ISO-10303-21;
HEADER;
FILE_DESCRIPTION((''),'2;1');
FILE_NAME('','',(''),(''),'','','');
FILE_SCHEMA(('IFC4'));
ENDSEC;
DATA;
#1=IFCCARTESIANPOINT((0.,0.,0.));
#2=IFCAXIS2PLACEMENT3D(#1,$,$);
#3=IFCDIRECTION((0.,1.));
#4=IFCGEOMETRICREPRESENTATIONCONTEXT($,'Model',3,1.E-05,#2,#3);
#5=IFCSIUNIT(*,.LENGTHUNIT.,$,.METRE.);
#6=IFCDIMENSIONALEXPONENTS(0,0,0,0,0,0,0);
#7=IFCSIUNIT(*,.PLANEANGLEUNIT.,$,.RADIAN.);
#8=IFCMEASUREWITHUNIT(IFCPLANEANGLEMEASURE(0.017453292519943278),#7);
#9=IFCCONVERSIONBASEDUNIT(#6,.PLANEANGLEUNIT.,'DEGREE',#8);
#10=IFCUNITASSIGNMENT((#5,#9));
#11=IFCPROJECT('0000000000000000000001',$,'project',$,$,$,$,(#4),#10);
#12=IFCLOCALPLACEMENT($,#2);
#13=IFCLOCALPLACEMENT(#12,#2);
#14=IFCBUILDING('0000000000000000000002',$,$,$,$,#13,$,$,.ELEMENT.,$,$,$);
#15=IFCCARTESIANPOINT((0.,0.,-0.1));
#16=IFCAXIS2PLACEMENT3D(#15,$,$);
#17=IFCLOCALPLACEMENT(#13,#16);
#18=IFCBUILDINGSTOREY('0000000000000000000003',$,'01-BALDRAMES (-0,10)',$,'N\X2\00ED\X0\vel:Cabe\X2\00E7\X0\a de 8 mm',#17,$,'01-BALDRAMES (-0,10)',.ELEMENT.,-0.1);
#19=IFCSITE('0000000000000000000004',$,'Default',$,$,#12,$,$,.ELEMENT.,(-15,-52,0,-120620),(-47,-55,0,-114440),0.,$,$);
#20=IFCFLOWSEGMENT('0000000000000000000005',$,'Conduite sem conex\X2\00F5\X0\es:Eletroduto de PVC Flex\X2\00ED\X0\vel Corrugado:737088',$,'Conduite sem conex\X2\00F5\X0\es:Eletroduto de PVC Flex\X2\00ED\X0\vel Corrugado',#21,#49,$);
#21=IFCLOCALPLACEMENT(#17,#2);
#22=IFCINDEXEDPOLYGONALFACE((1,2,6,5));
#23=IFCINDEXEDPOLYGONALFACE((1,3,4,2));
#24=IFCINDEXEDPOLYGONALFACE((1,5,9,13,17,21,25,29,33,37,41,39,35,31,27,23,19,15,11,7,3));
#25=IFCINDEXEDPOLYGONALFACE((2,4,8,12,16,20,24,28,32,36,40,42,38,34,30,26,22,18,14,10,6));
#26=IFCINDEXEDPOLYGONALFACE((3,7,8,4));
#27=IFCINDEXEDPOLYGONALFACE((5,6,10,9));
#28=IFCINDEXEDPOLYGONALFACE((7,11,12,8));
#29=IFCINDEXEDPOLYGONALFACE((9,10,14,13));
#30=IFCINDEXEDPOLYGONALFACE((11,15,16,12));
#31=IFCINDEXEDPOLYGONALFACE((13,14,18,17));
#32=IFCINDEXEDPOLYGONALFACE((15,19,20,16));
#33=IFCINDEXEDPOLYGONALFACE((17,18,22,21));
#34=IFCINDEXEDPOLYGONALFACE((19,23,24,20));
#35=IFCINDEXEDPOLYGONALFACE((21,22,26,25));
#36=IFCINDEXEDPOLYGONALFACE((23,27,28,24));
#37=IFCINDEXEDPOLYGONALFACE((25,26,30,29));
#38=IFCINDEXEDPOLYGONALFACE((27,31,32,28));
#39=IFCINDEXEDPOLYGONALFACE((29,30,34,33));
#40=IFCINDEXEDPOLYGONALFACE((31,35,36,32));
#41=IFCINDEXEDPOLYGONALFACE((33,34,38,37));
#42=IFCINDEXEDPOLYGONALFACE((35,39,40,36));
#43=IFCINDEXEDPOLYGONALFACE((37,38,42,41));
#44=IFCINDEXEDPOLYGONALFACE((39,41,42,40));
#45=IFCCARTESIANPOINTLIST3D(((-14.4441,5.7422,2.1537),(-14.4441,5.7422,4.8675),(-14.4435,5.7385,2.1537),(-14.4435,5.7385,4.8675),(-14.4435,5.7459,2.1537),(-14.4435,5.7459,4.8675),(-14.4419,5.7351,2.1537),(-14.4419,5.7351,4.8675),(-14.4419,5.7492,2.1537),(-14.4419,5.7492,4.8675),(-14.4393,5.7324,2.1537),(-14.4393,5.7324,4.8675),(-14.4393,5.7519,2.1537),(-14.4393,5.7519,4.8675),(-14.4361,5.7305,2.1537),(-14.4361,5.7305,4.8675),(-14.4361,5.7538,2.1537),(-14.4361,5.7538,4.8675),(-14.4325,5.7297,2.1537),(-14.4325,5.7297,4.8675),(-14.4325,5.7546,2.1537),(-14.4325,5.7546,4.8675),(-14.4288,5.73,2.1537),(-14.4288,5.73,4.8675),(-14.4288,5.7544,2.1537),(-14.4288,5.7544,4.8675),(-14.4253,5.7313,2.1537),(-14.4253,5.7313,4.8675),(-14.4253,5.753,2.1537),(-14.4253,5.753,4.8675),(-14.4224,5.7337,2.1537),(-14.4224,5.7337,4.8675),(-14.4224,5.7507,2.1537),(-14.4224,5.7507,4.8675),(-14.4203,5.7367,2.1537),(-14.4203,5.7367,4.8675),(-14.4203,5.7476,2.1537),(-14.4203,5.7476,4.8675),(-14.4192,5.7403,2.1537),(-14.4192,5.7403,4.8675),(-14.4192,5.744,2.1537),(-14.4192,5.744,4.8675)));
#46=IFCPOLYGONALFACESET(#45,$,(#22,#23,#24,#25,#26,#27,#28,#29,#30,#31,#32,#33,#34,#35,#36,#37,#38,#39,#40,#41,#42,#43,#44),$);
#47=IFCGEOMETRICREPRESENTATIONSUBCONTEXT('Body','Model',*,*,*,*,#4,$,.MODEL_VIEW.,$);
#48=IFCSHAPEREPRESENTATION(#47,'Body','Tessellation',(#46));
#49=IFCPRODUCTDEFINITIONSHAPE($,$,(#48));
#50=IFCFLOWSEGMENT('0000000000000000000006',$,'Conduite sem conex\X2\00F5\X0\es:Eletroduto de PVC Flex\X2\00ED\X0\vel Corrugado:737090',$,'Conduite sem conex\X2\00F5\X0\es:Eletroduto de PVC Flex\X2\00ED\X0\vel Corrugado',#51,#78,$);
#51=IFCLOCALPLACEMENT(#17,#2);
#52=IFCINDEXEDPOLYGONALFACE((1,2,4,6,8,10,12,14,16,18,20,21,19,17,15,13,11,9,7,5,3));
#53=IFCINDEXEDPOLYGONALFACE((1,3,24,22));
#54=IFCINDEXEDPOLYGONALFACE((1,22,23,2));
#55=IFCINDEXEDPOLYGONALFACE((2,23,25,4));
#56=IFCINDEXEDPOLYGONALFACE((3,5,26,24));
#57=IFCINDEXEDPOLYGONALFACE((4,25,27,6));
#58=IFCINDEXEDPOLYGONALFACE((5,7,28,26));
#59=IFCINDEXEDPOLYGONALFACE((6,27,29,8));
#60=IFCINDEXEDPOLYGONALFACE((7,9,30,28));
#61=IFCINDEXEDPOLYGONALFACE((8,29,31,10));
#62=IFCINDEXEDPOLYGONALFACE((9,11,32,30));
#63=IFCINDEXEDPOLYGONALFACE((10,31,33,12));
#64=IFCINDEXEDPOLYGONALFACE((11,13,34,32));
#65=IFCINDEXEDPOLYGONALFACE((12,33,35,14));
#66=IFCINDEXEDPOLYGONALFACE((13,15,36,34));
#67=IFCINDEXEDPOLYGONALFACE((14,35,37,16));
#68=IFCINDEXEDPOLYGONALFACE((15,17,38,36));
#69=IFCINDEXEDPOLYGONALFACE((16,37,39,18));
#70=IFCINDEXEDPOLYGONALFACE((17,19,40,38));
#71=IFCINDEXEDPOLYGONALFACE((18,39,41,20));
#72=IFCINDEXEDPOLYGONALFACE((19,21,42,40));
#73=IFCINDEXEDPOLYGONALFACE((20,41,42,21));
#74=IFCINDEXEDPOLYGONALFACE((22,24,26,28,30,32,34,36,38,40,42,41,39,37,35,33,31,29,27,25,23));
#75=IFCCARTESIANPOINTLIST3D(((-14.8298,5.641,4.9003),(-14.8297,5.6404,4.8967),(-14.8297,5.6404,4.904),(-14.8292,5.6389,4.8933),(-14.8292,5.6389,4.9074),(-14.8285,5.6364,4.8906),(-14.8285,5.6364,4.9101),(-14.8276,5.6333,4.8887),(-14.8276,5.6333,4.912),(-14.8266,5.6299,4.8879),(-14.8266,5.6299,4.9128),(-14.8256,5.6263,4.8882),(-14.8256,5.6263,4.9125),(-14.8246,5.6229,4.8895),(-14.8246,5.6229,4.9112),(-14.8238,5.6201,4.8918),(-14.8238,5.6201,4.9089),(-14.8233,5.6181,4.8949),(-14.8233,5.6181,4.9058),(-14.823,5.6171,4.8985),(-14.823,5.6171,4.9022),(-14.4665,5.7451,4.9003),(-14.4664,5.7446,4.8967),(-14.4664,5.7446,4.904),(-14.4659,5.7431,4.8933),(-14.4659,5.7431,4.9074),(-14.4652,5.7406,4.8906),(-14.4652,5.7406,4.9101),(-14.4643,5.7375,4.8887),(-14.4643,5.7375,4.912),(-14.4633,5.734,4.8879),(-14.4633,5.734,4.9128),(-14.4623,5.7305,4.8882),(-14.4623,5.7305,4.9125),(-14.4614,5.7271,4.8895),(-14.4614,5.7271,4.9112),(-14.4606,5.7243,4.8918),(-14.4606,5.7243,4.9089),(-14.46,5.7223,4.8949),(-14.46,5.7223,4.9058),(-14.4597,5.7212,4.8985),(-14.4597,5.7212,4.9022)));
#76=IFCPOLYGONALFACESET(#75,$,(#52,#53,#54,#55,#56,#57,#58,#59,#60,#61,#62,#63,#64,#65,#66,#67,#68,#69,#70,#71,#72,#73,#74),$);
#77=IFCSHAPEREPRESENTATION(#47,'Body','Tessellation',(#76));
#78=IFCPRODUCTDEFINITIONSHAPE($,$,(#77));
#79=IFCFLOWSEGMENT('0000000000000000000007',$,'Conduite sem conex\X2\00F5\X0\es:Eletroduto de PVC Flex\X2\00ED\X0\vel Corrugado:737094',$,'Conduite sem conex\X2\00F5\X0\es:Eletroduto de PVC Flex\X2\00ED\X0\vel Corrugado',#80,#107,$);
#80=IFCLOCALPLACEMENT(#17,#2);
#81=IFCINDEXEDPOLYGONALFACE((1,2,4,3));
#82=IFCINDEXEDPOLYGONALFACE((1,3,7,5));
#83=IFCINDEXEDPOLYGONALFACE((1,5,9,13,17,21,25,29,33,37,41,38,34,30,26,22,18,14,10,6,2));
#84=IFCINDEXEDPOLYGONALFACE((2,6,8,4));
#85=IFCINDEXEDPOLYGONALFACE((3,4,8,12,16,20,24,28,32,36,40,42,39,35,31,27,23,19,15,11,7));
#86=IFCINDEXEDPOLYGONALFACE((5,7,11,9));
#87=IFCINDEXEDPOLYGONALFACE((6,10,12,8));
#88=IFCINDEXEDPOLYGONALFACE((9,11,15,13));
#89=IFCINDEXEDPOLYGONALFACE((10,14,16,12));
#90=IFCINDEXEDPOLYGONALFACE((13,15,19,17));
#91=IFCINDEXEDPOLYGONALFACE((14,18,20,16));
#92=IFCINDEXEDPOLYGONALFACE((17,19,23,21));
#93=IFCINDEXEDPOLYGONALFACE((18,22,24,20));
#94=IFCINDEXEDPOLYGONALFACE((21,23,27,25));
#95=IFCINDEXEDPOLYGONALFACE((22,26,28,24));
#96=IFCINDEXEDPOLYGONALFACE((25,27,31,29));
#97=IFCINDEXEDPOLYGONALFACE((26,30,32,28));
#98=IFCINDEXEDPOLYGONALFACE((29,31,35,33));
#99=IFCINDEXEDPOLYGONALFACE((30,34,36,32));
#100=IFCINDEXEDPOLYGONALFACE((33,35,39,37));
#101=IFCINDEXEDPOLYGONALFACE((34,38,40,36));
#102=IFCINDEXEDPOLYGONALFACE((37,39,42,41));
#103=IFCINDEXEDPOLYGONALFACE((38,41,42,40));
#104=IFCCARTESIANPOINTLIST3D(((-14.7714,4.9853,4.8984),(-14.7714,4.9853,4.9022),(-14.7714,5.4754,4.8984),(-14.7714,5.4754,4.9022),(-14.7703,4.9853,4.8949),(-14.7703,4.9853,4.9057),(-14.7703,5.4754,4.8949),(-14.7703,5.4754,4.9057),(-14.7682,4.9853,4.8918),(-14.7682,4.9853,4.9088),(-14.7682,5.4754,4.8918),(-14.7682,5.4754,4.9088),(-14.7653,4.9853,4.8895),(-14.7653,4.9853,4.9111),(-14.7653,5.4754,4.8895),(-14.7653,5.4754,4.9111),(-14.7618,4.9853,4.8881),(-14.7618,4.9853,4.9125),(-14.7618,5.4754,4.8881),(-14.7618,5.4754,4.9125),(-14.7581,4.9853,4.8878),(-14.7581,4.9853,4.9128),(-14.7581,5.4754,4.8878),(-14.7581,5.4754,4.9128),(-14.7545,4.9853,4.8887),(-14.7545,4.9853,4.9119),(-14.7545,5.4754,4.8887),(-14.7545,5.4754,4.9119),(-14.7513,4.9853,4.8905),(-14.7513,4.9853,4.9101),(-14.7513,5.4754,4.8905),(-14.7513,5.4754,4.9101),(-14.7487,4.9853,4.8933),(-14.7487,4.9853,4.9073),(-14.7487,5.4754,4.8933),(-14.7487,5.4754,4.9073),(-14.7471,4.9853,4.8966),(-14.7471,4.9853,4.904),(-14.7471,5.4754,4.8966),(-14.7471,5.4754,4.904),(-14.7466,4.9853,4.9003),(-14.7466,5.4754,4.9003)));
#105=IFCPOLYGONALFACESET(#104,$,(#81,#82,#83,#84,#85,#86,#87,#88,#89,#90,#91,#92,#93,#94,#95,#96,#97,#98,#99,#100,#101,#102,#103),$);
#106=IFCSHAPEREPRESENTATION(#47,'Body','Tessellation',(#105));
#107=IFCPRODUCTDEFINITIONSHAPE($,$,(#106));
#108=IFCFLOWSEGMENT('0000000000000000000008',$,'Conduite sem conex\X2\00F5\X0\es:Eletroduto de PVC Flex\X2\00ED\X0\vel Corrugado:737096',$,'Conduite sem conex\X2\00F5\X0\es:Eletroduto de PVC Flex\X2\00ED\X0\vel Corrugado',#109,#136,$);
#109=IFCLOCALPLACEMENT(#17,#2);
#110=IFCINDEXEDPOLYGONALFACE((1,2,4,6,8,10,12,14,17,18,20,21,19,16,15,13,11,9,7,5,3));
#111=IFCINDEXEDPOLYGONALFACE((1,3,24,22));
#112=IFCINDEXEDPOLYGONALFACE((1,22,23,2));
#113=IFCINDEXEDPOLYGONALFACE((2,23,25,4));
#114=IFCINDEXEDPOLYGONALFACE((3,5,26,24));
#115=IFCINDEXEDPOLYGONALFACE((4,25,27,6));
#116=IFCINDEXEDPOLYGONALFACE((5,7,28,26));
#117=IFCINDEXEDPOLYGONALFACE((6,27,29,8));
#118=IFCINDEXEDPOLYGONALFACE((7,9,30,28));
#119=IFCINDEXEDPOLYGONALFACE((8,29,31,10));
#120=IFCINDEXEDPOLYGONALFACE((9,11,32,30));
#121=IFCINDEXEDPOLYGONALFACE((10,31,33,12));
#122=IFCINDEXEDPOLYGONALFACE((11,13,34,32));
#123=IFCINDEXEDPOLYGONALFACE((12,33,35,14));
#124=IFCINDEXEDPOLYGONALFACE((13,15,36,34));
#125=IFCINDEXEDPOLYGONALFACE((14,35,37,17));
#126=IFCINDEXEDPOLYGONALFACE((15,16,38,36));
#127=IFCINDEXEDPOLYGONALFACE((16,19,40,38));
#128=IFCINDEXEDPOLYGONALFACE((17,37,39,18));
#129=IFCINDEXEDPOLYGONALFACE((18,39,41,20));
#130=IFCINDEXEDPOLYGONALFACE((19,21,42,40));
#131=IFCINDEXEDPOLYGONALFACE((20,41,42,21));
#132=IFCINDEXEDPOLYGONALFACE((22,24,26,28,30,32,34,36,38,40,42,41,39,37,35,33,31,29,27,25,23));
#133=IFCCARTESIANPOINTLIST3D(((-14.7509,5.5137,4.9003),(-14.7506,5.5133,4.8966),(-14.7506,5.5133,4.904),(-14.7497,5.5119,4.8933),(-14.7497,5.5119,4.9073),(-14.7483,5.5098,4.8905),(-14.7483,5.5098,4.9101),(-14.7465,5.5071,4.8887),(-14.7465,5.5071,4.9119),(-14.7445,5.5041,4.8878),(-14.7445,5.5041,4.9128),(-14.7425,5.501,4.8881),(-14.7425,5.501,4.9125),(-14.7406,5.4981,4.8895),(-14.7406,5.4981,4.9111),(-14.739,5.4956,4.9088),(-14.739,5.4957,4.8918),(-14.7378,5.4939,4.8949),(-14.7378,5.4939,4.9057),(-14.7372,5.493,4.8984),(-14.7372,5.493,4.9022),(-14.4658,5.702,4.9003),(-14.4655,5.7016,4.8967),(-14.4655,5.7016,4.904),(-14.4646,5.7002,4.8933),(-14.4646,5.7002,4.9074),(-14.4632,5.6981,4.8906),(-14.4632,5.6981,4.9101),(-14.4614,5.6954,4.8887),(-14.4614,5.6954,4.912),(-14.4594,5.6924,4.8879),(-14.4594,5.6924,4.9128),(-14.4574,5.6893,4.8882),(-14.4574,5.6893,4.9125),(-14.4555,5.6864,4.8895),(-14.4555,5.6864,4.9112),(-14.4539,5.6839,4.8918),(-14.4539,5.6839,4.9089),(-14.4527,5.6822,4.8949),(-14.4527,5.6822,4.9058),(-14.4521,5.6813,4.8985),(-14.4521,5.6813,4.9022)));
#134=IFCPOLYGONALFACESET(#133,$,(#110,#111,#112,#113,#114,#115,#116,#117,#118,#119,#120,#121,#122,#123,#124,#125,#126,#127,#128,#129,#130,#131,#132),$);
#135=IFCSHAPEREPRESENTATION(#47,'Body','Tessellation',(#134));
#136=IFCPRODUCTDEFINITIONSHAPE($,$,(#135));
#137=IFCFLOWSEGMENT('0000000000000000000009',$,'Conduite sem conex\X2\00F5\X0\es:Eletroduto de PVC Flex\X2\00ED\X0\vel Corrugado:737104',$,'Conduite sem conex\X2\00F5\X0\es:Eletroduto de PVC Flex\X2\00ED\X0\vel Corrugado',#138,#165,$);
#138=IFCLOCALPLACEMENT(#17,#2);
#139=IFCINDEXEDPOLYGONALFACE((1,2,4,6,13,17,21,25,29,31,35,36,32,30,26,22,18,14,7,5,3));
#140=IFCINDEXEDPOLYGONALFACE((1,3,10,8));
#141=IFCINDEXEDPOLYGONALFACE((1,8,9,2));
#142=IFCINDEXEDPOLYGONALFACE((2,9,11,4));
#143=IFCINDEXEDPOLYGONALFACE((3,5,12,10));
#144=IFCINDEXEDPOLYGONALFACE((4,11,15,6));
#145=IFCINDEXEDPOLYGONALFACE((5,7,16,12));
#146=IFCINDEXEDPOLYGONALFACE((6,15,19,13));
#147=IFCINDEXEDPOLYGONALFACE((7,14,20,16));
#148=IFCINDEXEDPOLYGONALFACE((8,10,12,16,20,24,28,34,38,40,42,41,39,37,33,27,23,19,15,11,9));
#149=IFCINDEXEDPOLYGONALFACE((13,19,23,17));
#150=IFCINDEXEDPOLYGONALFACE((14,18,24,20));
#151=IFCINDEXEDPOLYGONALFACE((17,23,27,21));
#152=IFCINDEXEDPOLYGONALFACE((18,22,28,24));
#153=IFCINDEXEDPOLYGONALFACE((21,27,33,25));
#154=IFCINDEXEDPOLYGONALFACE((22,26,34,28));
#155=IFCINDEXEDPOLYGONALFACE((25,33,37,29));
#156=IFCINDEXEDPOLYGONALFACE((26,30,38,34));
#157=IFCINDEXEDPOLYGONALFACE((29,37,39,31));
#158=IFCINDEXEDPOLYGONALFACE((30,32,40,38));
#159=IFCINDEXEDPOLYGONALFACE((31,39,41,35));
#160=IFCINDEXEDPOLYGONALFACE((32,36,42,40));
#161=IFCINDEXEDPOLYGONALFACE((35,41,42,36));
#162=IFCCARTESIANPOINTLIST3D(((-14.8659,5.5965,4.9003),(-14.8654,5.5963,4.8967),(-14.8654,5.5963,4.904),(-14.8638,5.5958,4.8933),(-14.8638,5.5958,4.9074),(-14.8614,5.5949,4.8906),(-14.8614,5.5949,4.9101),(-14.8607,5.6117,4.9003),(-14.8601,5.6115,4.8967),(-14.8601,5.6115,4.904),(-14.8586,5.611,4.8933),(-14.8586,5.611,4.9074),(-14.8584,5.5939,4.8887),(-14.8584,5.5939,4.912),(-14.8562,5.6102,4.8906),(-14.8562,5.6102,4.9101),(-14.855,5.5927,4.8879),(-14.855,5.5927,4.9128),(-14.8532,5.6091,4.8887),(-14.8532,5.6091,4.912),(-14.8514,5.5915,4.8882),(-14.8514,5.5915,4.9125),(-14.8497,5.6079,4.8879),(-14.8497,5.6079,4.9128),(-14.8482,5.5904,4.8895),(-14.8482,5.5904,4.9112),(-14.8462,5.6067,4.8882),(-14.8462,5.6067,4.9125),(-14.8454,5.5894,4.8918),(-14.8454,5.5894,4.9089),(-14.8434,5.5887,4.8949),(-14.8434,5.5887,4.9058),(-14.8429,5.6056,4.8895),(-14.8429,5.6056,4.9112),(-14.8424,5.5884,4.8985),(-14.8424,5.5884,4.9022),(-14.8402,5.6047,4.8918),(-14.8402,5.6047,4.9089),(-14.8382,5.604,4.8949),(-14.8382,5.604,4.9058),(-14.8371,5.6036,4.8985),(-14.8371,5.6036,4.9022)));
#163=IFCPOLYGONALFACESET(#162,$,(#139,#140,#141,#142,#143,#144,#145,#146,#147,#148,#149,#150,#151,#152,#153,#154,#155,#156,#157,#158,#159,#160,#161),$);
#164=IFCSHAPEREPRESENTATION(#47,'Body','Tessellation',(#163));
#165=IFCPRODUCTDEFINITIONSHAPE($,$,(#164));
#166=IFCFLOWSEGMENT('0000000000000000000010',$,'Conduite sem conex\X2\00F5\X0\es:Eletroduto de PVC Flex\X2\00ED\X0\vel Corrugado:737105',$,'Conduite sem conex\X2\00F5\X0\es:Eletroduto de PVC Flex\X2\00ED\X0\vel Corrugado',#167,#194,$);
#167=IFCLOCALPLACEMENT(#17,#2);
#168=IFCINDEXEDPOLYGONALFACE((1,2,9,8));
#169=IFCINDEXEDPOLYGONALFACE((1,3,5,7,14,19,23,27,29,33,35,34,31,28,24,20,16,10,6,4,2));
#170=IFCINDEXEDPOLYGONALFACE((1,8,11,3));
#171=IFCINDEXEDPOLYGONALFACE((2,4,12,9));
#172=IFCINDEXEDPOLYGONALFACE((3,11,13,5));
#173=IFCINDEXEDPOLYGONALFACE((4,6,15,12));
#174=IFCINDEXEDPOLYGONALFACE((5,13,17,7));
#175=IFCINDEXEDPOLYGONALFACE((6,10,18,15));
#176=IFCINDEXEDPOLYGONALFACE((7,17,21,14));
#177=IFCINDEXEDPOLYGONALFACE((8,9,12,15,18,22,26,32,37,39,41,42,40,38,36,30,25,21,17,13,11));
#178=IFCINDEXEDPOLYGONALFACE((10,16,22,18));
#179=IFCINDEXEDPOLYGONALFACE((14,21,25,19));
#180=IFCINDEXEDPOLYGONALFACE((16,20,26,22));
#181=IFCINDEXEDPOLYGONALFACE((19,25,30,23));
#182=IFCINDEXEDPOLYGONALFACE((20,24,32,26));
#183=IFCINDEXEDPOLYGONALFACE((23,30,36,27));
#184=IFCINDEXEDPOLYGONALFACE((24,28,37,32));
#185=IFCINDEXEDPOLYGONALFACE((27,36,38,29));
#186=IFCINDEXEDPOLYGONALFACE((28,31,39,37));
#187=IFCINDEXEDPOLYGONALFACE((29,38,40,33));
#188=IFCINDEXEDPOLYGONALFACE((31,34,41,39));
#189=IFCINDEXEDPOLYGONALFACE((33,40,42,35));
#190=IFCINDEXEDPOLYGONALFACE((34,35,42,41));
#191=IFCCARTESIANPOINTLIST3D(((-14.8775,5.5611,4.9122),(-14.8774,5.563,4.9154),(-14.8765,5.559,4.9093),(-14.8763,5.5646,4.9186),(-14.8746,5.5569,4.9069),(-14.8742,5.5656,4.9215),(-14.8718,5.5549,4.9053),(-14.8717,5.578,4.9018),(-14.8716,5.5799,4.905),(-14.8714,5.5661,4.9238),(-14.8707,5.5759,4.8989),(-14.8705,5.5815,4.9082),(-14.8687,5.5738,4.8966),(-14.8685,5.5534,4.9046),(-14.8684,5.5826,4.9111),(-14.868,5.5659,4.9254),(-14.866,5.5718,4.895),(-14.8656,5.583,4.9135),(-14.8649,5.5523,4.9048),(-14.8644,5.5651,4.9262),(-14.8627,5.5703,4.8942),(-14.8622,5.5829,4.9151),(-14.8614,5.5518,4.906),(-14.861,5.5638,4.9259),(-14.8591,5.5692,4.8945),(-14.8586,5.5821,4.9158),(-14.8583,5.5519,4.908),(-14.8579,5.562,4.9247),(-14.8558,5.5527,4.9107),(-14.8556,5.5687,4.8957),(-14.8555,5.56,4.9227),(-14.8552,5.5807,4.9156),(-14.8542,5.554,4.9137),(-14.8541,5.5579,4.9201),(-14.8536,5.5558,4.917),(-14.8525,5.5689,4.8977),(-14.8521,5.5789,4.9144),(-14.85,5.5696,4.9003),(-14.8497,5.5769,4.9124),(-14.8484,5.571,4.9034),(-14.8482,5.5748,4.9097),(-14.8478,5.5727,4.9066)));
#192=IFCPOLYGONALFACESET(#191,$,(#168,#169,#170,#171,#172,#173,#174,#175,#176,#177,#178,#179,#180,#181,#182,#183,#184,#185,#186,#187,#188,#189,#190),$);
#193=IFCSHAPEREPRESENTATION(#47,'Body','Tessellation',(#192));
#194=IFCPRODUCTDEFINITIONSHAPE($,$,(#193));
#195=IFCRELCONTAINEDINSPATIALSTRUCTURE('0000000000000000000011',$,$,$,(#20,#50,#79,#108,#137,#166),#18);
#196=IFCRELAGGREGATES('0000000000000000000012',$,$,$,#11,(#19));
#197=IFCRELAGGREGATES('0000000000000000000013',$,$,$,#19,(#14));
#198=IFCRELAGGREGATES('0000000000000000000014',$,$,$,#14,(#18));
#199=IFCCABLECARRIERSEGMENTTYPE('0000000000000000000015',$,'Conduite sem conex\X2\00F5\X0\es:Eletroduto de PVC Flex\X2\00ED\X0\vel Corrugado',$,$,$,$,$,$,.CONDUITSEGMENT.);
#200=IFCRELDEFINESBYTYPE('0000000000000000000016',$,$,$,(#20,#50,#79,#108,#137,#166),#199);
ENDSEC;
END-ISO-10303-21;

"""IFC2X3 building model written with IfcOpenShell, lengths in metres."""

from ifc_helpers import new_model, entity, si_unit, converted_unit, direction, frame, frame_2d, origin, origin_2d_with_axis, place, context, subcontext, project, spatial, circle, extrude, type_object, element, save


model = new_model("IFC2X3")

# Units and contexts
model_context = context("Model", 3, precision=1e-05, world=origin(), true_north=direction((0.0, 1.0)))
body_context = subcontext(model_context, "Body", "Model", "MODEL_VIEW")
ifc_project = project(units=[si_unit("LENGTHUNIT", "METRE"), converted_unit("PLANEANGLEUNIT", "DEGREE", entity("IfcPlaneAngleMeasure", 0.017453292519943278), si_unit("PLANEANGLEUNIT", "RADIAN"), dimensions=[0, 0, 0, 0, 0, 0, 0])], contexts=[model_context])

# Site, building, storey
site_placement = place(None, origin())
site = spatial("IfcSite", under=ifc_project, at=site_placement, Name="Default", CompositionType="ELEMENT", RefLatitude=(-15, -52, 0, -120620), RefLongitude=(-47, -55, 0, -114440), RefElevation=0.0)
building_placement = place(site_placement, origin())
building = spatial("IfcBuilding", under=site, at=building_placement, CompositionType="ELEMENT")
storey_placement = place(building_placement, frame((0.0, 0.0, -0.1)))
storey = spatial("IfcBuildingStorey", under=building, at=storey_placement, Name="01-BALDRAMES (-0,10)", ObjectType="Nível:Cabeça de 8 mm", LongName="01-BALDRAMES (-0,10)", CompositionType="ELEMENT", Elevation=-0.1)

# Flow segments
cable_carrier_segment_type = type_object("IfcCableCarrierSegmentType", Name="Conduite sem conexões:Eletroduto de PVC Flexível Corrugado", PredefinedType="CONDUITSEGMENT")
flow_segment_1_placement = place(storey_placement, origin())
element("IfcFlowSegment", 1, at=flow_segment_1_placement, inside=storey, type_object=cable_carrier_segment_type, Name="Conduite sem conexões:Eletroduto de PVC Flexível Corrugado:737088", ObjectType="Conduite sem conexões:Eletroduto de PVC Flexível Corrugado", context=body_context, shape_type="SweptSolid", body=[
    extrude(circle(Radius=0.0125, at=frame_2d((0.0, 0.0), x_axis=(1.0, 0.0))), frame((-14.4316, 5.7422, 2.1537), z_axis=(0.0, 0.0, 1.0), x_axis=(-1.0, 0.0, 0.0)), (0.0, 0.0, 1.0), 2.7138),
])
flow_segment_2_placement = place(storey_placement, origin())
element("IfcFlowSegment", 2, at=flow_segment_2_placement, inside=storey, type_object=cable_carrier_segment_type, Name="Conduite sem conexões:Eletroduto de PVC Flexível Corrugado:737090", ObjectType="Conduite sem conexões:Eletroduto de PVC Flexível Corrugado", context=body_context, shape_type="SweptSolid", body=[
    extrude(circle(Radius=0.0125, at=frame_2d((0.0, 0.0), x_axis=(1.0, 0.0))), frame((-14.8264, 5.629, 4.9003), z_axis=(0.961262, 0.275637, 0.0), x_axis=(-0.275637, 0.961262, 0.0)), (0.0, 0.0, 1.0), 0.3779),
])
flow_segment_3_placement = place(storey_placement, origin())
element("IfcFlowSegment", 3, at=flow_segment_3_placement, inside=storey, type_object=cable_carrier_segment_type, Name="Conduite sem conexões:Eletroduto de PVC Flexível Corrugado:737094", ObjectType="Conduite sem conexões:Eletroduto de PVC Flexível Corrugado", context=body_context, shape_type="SweptSolid", body=[
    extrude(circle(Radius=0.0125, at=frame_2d((0.0, 0.0), x_axis=(1.0, 0.0))), frame((-14.7591, 4.9853, 4.9003), z_axis=(0.0, 1.0, 0.0), x_axis=(1.0, 0.0, 0.0)), (0.0, 0.0, 1.0), 0.4901),
])
flow_segment_4_placement = place(storey_placement, origin())
element("IfcFlowSegment", 4, at=flow_segment_4_placement, inside=storey, type_object=cable_carrier_segment_type, Name="Conduite sem conexões:Eletroduto de PVC Flexível Corrugado:737096", ObjectType="Conduite sem conexões:Eletroduto de PVC Flexível Corrugado", context=body_context, shape_type="SweptSolid", body=[
    extrude(circle(Radius=0.0125, at=frame_2d((0.0, 0.0), x_axis=(1.0, 0.0))), frame((-14.744, 5.5033, 4.9003), z_axis=(0.834434, 0.551108, 0.000139), x_axis=(-0.551108, 0.834434, 0.0)), (0.0, 0.0, 1.0), 0.3417),
])
flow_segment_5_placement = place(storey_placement, origin())
element("IfcFlowSegment", 5, at=flow_segment_5_placement, inside=storey, type_object=cable_carrier_segment_type, Name="Conduite sem conexões:Eletroduto de PVC Flexível Corrugado:737104", ObjectType="Conduite sem conexões:Eletroduto de PVC Flexível Corrugado", context=body_context, shape_type="SweptSolid", body=[
    extrude(circle(Radius=0.0125, at=frame_2d((0.0, 0.0), x_axis=(1.0, 0.0))), frame((-14.8541, 5.5924, 4.9003), z_axis=(0.325512, 0.945538, 0.0), x_axis=(-0.945538, 0.325512, 0.0)), (0.0, 0.0, 1.0), 0.0161),
])
flow_segment_6_placement = place(storey_placement, origin())
element("IfcFlowSegment", 6, at=flow_segment_6_placement, inside=storey, type_object=cable_carrier_segment_type, Name="Conduite sem conexões:Eletroduto de PVC Flexível Corrugado:737105", ObjectType="Conduite sem conexões:Eletroduto de PVC Flexível Corrugado", context=body_context, shape_type="SweptSolid", body=[
    extrude(circle(Radius=0.0125, at=origin_2d_with_axis()), frame((-14.8598, 5.5759, 4.905), z_axis=(-0.281901, -0.818858, 0.500003), x_axis=(-0.945538, 0.325512, 0.0)), (0.0, 0.0, 1.0), 0.0207),
])

save(model, "model.ifc")
